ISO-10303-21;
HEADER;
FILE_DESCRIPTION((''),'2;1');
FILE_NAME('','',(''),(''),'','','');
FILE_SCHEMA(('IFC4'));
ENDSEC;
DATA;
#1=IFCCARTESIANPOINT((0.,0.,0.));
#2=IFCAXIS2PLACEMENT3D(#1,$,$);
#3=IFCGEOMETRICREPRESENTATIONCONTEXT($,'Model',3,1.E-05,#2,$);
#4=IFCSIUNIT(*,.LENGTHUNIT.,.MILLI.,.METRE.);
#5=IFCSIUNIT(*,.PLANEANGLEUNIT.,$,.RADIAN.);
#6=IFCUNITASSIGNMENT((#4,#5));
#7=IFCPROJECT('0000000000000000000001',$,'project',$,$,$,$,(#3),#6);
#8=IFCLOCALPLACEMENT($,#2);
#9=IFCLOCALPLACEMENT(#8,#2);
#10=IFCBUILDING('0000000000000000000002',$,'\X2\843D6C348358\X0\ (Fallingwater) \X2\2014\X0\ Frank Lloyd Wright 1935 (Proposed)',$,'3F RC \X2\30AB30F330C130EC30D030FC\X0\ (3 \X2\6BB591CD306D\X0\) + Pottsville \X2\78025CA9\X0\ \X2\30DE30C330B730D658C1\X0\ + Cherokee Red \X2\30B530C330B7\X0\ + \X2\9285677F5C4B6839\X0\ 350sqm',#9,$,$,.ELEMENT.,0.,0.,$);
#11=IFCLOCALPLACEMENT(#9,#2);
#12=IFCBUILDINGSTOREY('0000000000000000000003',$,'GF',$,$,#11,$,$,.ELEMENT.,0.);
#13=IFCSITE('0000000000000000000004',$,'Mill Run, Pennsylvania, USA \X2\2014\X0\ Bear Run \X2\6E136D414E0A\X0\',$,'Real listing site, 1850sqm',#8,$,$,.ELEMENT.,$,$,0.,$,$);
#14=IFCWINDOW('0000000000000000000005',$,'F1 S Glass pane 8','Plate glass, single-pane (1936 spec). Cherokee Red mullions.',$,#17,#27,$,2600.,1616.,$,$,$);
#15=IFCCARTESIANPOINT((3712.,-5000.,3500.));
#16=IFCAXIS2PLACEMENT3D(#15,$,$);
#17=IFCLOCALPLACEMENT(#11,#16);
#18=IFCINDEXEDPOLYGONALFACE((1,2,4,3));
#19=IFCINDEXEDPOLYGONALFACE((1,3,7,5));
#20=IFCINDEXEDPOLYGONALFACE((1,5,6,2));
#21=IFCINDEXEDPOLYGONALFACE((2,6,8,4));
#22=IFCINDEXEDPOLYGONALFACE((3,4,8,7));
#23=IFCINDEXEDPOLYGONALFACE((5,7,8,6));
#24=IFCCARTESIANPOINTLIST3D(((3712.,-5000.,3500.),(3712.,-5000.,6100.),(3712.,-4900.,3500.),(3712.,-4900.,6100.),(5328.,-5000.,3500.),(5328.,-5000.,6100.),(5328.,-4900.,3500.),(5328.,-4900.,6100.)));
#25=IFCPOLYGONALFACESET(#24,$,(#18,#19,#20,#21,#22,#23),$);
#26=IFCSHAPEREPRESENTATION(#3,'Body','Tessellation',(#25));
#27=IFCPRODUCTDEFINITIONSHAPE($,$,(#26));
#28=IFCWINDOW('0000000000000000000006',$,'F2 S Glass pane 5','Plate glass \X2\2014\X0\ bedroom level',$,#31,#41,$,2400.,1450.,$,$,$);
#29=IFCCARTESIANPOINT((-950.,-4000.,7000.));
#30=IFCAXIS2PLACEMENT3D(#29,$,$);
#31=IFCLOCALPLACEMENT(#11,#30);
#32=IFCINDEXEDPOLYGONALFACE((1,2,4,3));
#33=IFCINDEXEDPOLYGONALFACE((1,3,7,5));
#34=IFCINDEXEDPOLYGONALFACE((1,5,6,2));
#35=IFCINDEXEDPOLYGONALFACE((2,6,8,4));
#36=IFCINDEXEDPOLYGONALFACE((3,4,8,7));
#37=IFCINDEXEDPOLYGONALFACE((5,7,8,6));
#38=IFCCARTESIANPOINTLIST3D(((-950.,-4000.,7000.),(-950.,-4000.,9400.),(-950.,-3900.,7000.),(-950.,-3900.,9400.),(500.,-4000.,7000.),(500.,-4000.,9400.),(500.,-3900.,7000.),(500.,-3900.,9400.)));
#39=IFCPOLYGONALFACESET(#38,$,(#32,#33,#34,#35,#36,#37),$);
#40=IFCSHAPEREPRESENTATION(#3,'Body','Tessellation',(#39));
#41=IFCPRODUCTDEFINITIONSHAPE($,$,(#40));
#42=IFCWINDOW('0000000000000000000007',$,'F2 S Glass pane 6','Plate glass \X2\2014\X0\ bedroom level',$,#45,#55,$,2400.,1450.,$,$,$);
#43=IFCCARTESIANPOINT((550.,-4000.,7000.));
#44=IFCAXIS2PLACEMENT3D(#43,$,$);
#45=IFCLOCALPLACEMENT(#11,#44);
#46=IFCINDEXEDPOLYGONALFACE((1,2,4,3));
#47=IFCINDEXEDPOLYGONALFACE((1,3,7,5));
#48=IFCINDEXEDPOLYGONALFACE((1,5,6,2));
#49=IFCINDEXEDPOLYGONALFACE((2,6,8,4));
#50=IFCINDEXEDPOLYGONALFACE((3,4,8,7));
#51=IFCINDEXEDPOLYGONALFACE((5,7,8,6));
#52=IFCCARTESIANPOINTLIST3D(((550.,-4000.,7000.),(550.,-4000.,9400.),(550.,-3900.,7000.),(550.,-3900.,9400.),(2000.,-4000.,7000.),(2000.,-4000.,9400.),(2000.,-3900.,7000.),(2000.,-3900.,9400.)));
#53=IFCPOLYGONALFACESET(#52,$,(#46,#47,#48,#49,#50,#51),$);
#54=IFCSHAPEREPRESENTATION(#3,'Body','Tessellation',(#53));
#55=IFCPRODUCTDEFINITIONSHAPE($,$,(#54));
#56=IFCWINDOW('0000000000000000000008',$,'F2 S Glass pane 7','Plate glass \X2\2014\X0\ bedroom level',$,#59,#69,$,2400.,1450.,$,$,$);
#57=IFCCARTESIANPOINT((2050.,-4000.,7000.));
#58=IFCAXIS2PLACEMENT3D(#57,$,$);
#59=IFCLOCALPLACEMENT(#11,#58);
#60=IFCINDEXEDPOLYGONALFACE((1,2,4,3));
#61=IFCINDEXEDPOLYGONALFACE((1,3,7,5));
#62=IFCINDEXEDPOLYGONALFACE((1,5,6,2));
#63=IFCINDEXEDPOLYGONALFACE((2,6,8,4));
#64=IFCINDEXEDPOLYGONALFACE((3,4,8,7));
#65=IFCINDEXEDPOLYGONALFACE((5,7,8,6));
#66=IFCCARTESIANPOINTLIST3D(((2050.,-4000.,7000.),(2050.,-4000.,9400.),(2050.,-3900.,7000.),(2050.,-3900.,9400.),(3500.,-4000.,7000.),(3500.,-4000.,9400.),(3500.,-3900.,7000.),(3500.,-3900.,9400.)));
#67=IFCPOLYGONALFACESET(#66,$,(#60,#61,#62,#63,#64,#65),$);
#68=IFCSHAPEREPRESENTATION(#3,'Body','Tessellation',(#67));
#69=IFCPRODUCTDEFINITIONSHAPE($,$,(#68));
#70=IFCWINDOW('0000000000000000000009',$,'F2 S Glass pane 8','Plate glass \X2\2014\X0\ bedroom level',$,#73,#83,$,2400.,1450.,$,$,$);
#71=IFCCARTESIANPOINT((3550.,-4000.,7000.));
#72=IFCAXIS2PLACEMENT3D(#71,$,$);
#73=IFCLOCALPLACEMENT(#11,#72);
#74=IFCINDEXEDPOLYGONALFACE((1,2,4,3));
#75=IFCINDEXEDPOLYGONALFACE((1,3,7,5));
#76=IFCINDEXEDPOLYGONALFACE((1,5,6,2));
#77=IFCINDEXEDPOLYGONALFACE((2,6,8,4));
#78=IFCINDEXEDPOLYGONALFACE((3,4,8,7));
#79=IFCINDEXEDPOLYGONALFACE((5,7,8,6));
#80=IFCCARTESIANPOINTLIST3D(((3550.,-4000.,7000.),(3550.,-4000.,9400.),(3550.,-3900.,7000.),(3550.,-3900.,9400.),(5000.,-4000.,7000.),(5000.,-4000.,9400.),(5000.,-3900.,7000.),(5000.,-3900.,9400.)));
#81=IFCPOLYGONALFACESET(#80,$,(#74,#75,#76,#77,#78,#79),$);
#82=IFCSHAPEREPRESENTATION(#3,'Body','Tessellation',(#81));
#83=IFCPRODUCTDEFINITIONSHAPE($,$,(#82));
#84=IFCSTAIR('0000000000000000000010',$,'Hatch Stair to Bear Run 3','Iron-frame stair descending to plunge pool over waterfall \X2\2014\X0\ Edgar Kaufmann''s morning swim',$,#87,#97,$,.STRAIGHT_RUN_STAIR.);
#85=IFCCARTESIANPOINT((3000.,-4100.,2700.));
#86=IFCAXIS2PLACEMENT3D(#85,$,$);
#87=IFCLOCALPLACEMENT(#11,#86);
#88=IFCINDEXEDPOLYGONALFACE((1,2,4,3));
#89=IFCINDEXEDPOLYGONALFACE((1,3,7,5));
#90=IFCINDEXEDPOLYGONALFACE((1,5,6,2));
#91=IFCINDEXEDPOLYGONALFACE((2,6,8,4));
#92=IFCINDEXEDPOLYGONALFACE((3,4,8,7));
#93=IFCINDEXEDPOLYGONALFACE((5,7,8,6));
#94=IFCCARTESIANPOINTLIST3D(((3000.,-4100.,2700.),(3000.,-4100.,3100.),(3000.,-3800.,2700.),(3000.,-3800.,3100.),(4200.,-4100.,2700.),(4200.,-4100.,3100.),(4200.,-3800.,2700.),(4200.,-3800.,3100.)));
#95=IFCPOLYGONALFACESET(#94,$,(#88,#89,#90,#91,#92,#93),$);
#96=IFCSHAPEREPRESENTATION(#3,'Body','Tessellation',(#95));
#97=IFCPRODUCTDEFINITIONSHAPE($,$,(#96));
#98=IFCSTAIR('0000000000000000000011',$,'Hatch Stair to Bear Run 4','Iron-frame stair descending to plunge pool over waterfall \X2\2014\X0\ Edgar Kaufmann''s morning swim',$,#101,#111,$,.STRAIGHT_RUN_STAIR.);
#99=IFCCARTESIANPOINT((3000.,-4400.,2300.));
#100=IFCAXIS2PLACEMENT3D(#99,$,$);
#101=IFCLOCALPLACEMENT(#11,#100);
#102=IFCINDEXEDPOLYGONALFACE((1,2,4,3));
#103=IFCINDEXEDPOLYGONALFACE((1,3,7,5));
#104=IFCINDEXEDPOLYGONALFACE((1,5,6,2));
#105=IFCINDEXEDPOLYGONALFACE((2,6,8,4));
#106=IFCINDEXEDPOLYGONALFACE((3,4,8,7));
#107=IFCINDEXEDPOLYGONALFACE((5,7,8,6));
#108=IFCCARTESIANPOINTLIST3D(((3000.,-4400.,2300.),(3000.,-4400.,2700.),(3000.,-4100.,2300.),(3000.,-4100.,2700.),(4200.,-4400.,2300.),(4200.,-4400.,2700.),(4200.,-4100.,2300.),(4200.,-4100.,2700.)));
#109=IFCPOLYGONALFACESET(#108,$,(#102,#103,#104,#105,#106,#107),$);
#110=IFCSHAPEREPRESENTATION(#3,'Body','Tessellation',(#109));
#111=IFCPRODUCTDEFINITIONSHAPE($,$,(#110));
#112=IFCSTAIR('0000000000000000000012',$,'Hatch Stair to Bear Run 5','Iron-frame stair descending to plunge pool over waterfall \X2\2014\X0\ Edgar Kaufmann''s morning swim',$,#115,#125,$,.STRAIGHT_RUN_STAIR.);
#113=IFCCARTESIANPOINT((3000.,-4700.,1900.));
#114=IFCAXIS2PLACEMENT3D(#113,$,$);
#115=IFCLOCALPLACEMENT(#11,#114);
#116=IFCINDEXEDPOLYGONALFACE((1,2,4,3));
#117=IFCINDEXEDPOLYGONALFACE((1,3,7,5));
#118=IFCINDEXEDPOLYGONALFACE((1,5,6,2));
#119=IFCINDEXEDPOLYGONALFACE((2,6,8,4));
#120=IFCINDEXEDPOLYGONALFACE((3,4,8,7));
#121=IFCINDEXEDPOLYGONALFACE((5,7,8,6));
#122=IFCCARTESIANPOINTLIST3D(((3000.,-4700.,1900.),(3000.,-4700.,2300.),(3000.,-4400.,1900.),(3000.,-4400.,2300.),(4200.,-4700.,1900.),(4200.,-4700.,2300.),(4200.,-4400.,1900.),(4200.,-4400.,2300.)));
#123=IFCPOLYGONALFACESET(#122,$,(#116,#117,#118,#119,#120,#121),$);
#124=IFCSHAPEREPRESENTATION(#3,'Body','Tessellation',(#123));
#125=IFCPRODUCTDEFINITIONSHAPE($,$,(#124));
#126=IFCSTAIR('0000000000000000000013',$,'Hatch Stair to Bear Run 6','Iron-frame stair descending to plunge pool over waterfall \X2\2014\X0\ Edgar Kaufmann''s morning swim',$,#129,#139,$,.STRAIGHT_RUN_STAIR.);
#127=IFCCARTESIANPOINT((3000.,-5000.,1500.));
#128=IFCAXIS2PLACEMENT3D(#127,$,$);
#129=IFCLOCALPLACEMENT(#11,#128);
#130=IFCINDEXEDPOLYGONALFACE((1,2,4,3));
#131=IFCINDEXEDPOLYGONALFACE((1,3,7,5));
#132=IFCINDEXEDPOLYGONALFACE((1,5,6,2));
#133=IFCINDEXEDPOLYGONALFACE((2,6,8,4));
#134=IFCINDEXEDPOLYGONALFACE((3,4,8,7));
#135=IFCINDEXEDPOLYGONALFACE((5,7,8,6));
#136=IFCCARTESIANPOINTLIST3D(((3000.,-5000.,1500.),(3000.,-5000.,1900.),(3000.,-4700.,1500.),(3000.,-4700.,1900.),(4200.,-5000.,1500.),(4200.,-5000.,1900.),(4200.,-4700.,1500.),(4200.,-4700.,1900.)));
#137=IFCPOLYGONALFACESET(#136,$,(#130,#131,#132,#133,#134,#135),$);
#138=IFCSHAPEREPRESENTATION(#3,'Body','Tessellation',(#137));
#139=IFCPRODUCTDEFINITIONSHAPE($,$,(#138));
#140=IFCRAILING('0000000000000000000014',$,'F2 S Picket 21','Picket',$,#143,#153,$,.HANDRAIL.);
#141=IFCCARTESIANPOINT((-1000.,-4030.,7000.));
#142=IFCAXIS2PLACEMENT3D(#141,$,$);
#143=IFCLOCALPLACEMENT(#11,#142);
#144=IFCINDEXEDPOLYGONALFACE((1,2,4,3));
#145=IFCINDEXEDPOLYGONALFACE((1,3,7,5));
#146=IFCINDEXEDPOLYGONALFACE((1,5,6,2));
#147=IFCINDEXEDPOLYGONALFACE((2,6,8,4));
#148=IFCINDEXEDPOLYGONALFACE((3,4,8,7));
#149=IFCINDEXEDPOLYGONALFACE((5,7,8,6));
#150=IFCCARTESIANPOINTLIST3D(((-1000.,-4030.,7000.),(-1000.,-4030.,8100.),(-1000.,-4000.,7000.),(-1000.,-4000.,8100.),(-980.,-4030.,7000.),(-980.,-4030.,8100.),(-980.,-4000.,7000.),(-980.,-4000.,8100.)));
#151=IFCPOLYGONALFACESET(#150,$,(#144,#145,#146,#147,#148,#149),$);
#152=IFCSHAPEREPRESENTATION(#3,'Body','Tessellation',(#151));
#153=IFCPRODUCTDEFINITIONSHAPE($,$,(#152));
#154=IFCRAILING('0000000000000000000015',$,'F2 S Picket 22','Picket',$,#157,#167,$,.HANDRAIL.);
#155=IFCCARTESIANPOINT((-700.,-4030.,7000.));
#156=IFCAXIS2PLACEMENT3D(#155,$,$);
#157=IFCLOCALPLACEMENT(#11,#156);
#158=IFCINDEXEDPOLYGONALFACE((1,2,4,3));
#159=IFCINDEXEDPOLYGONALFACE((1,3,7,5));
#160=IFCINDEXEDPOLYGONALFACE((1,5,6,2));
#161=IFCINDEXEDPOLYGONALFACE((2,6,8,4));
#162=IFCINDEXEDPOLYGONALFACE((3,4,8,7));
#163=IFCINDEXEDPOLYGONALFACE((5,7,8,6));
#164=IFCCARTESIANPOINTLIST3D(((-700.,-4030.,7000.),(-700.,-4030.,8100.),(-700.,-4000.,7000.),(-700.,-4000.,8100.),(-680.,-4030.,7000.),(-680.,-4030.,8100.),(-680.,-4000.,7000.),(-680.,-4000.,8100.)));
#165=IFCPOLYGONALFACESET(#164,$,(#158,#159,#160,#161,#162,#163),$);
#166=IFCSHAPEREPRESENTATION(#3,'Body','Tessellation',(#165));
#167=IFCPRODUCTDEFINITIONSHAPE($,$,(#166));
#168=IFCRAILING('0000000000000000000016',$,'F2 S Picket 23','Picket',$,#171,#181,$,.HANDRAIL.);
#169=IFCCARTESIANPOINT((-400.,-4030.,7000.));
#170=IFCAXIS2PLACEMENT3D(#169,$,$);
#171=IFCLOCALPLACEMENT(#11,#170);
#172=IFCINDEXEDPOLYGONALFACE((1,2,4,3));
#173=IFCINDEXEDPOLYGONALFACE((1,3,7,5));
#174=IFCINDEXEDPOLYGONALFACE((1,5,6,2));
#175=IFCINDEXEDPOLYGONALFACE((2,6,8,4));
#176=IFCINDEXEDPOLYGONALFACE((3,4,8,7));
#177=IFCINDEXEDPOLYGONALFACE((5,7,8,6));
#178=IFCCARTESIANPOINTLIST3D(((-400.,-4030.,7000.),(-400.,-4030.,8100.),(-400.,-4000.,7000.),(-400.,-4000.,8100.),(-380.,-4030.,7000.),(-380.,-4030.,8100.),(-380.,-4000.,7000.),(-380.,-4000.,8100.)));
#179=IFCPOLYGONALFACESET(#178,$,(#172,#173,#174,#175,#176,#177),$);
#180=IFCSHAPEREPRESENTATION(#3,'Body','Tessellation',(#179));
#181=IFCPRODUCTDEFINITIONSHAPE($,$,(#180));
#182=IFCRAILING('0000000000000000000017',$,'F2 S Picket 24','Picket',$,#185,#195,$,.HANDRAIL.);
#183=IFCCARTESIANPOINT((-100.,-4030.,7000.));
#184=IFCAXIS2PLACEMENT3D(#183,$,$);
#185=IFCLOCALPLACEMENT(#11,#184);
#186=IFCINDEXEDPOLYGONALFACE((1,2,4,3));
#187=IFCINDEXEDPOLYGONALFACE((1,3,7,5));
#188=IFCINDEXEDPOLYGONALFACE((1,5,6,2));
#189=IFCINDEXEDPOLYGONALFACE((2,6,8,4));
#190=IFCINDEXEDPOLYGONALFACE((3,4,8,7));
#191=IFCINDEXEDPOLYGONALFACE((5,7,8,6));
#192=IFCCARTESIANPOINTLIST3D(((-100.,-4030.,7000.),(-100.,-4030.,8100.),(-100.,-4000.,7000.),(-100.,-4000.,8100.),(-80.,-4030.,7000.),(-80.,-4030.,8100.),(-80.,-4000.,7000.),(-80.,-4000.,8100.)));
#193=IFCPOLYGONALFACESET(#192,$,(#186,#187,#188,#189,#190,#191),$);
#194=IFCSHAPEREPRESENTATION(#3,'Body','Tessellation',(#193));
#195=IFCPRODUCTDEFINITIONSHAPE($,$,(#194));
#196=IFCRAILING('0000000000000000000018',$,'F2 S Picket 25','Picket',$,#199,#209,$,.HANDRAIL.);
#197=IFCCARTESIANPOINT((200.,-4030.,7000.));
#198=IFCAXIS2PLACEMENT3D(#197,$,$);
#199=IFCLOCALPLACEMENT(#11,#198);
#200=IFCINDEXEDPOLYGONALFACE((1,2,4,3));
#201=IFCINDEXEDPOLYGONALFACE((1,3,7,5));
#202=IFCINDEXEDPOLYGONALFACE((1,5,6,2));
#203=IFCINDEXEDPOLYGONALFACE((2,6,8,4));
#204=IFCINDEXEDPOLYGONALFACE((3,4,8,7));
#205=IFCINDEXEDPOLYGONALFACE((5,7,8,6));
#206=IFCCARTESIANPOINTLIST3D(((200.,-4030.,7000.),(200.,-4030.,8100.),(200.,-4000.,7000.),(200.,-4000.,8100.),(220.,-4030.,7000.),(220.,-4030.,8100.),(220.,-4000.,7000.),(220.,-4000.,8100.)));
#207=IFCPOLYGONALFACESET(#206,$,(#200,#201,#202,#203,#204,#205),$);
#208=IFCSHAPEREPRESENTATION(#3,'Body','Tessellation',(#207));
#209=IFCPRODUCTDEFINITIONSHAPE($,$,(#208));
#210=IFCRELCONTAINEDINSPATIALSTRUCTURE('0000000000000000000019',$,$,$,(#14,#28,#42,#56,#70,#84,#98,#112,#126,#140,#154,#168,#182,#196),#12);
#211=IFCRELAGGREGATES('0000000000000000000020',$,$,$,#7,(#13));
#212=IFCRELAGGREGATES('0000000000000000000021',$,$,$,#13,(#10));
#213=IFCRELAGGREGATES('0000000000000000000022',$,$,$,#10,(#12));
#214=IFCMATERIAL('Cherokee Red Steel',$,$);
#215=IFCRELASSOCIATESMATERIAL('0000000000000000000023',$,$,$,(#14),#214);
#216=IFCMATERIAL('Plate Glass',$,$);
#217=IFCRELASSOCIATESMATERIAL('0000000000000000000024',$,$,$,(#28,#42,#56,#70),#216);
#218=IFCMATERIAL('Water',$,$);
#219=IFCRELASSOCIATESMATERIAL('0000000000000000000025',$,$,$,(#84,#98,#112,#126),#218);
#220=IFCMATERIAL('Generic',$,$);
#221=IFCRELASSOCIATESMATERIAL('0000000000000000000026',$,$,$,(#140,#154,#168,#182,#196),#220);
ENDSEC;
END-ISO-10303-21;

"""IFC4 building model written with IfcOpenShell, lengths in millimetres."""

from ifc_helpers import new_model, si_unit, frame, frame_2d, origin, place, context, project, spatial, rectangle, extrude, material, element, save


model = new_model("IFC4")

# Units and contexts
model_context = context("Model", 3, precision=1e-05, world=origin())
ifc_project = project(units=[si_unit("LENGTHUNIT", "METRE", prefix="MILLI"), si_unit("PLANEANGLEUNIT", "RADIAN")], contexts=[model_context])

# Site, building, storey
site_placement = place(None, origin())
site = spatial("IfcSite", under=ifc_project, at=site_placement, Name="Mill Run, Pennsylvania, USA — Bear Run 渓流上", ObjectType="Real listing site, 1850sqm", CompositionType="ELEMENT", RefElevation=0.0)
building_placement = place(site_placement, origin())
building = spatial("IfcBuilding", under=site, at=building_placement, Name="落水荘 (Fallingwater) — Frank Lloyd Wright 1935 (Proposed)", ObjectType="3F RC カンチレバー (3 段重ね) + Pottsville 砂岩 マッシブ壁 + Cherokee Red サッシ + 銅板屋根 350sqm", CompositionType="ELEMENT", ElevationOfRefHeight=0.0, ElevationOfTerrain=0.0)
storey_placement = place(building_placement, origin())
storey = spatial("IfcBuildingStorey", under=building, at=storey_placement, Name="GF", CompositionType="ELEMENT", Elevation=0.0)

# Windows
ifc_material_1 = material(Name="Cherokee Red Steel")
window_1_placement = place(storey_placement, frame((3712.0, -5000.0, 3500.0)))
element("IfcWindow", 1, at=window_1_placement, inside=storey, material=ifc_material_1, Name="F1 S Glass pane 8", Description="Plate glass, single-pane (1936 spec). Cherokee Red mullions.", OverallHeight=2600.0, OverallWidth=1616.0, context=model_context, shape_type="SweptSolid", body=[
    extrude(rectangle(XDim=1616.0, YDim=100.0, at=frame_2d((808.0, 50.0))), frame((3712.0, -5000.0, 3500.0)), (0.0, 0.0, 1.0), 2600.0),
])
ifc_material_2 = material(Name="Plate Glass")
window_2_placement = place(storey_placement, frame((-950.0, -4000.0, 7000.0)))
element("IfcWindow", 2, at=window_2_placement, inside=storey, material=ifc_material_2, Name="F2 S Glass pane 5", Description="Plate glass — bedroom level", OverallHeight=2400.0, OverallWidth=1450.0, context=model_context, shape_type="SweptSolid", body=[
    extrude(rectangle(XDim=1450.0, YDim=100.0, at=frame_2d((725.0, 50.0))), frame((-950.0, -4000.0, 7000.0)), (0.0, 0.0, 1.0), 2400.0),
])
window_3_placement = place(storey_placement, frame((550.0, -4000.0, 7000.0)))
element("IfcWindow", 3, at=window_3_placement, inside=storey, material=ifc_material_2, Name="F2 S Glass pane 6", Description="Plate glass — bedroom level", OverallHeight=2400.0, OverallWidth=1450.0, context=model_context, shape_type="SweptSolid", body=[
    extrude(rectangle(XDim=1450.0, YDim=100.0, at=frame_2d((725.0, 50.0))), frame((550.0, -4000.0, 7000.0)), (0.0, 0.0, 1.0), 2400.0),
])
window_4_placement = place(storey_placement, frame((2050.0, -4000.0, 7000.0)))
element("IfcWindow", 4, at=window_4_placement, inside=storey, material=ifc_material_2, Name="F2 S Glass pane 7", Description="Plate glass — bedroom level", OverallHeight=2400.0, OverallWidth=1450.0, context=model_context, shape_type="SweptSolid", body=[
    extrude(rectangle(XDim=1450.0, YDim=100.0, at=frame_2d((725.0, 50.0))), frame((2050.0, -4000.0, 7000.0)), (0.0, 0.0, 1.0), 2400.0),
])
window_5_placement = place(storey_placement, frame((3550.0, -4000.0, 7000.0)))
element("IfcWindow", 5, at=window_5_placement, inside=storey, material=ifc_material_2, Name="F2 S Glass pane 8", Description="Plate glass — bedroom level", OverallHeight=2400.0, OverallWidth=1450.0, context=model_context, shape_type="SweptSolid", body=[
    extrude(rectangle(XDim=1450.0, YDim=100.0, at=frame_2d((725.0, 50.0))), frame((3550.0, -4000.0, 7000.0)), (0.0, 0.0, 1.0), 2400.0),
])

# Stairs
ifc_material_3 = material(Name="Water")
stair_1_placement = place(storey_placement, frame((3000.0, -4100.0, 2700.0)))
element("IfcStair", 6, at=stair_1_placement, inside=storey, material=ifc_material_3, Name="Hatch Stair to Bear Run 3", Description="Iron-frame stair descending to plunge pool over waterfall — Edgar Kaufmann's morning swim", PredefinedType="STRAIGHT_RUN_STAIR", context=model_context, shape_type="SweptSolid", body=[
    extrude(rectangle(XDim=1200.0, YDim=300.0, at=frame_2d((600.0, 150.0))), frame((3000.0, -4100.0, 2700.0)), (0.0, 0.0, 1.0), 400.0),
])
stair_2_placement = place(storey_placement, frame((3000.0, -4400.0, 2300.0)))
element("IfcStair", 7, at=stair_2_placement, inside=storey, material=ifc_material_3, Name="Hatch Stair to Bear Run 4", Description="Iron-frame stair descending to plunge pool over waterfall — Edgar Kaufmann's morning swim", PredefinedType="STRAIGHT_RUN_STAIR", context=model_context, shape_type="SweptSolid", body=[
    extrude(rectangle(XDim=1200.0, YDim=300.0, at=frame_2d((600.0, 150.0))), frame((3000.0, -4400.0, 2300.0)), (0.0, 0.0, 1.0), 400.0),
])
stair_3_placement = place(storey_placement, frame((3000.0, -4700.0, 1900.0)))
element("IfcStair", 8, at=stair_3_placement, inside=storey, material=ifc_material_3, Name="Hatch Stair to Bear Run 5", Description="Iron-frame stair descending to plunge pool over waterfall — Edgar Kaufmann's morning swim", PredefinedType="STRAIGHT_RUN_STAIR", context=model_context, shape_type="SweptSolid", body=[
    extrude(rectangle(XDim=1200.0, YDim=300.0, at=frame_2d((600.0, 150.0))), frame((3000.0, -4700.0, 1900.0)), (0.0, 0.0, 1.0), 400.0),
])
stair_4_placement = place(storey_placement, frame((3000.0, -5000.0, 1500.0)))
element("IfcStair", 9, at=stair_4_placement, inside=storey, material=ifc_material_3, Name="Hatch Stair to Bear Run 6", Description="Iron-frame stair descending to plunge pool over waterfall — Edgar Kaufmann's morning swim", PredefinedType="STRAIGHT_RUN_STAIR", context=model_context, shape_type="SweptSolid", body=[
    extrude(rectangle(XDim=1200.0, YDim=300.0, at=frame_2d((600.0, 150.0))), frame((3000.0, -5000.0, 1500.0)), (0.0, 0.0, 1.0), 400.0),
])

# Railings
ifc_material_4 = material(Name="Generic")
railing_1_placement = place(storey_placement, frame((-1000.0, -4030.0, 7000.0)))
element("IfcRailing", 10, at=railing_1_placement, inside=storey, material=ifc_material_4, Name="F2 S Picket 21", Description="Picket", PredefinedType="HANDRAIL", context=model_context, shape_type="SweptSolid", body=[
    extrude(rectangle(XDim=20.0, YDim=30.0, at=frame_2d((10.0, 15.0))), frame((-1000.0, -4030.0, 7000.0)), (0.0, 0.0, 1.0), 1100.0),
])
railing_2_placement = place(storey_placement, frame((-700.0, -4030.0, 7000.0)))
element("IfcRailing", 11, at=railing_2_placement, inside=storey, material=ifc_material_4, Name="F2 S Picket 22", Description="Picket", PredefinedType="HANDRAIL", context=model_context, shape_type="SweptSolid", body=[
    extrude(rectangle(XDim=20.0, YDim=30.0, at=frame_2d((10.0, 15.0))), frame((-700.0, -4030.0, 7000.0)), (0.0, 0.0, 1.0), 1100.0),
])
railing_3_placement = place(storey_placement, frame((-400.0, -4030.0, 7000.0)))
element("IfcRailing", 12, at=railing_3_placement, inside=storey, material=ifc_material_4, Name="F2 S Picket 23", Description="Picket", PredefinedType="HANDRAIL", context=model_context, shape_type="SweptSolid", body=[
    extrude(rectangle(XDim=20.0, YDim=30.0, at=frame_2d((10.0, 15.0))), frame((-400.0, -4030.0, 7000.0)), (0.0, 0.0, 1.0), 1100.0),
])
railing_4_placement = place(storey_placement, frame((-100.0, -4030.0, 7000.0)))
element("IfcRailing", 13, at=railing_4_placement, inside=storey, material=ifc_material_4, Name="F2 S Picket 24", Description="Picket", PredefinedType="HANDRAIL", context=model_context, shape_type="SweptSolid", body=[
    extrude(rectangle(XDim=20.0, YDim=30.0, at=frame_2d((10.0, 15.0))), frame((-100.0, -4030.0, 7000.0)), (0.0, 0.0, 1.0), 1100.0),
])
railing_5_placement = place(storey_placement, frame((200.0, -4030.0, 7000.0)))
element("IfcRailing", 14, at=railing_5_placement, inside=storey, material=ifc_material_4, Name="F2 S Picket 25", Description="Picket", PredefinedType="HANDRAIL", context=model_context, shape_type="SweptSolid", body=[
    extrude(rectangle(XDim=20.0, YDim=30.0, at=frame_2d((10.0, 15.0))), frame((200.0, -4030.0, 7000.0)), (0.0, 0.0, 1.0), 1100.0),
])

save(model, "model.ifc")
